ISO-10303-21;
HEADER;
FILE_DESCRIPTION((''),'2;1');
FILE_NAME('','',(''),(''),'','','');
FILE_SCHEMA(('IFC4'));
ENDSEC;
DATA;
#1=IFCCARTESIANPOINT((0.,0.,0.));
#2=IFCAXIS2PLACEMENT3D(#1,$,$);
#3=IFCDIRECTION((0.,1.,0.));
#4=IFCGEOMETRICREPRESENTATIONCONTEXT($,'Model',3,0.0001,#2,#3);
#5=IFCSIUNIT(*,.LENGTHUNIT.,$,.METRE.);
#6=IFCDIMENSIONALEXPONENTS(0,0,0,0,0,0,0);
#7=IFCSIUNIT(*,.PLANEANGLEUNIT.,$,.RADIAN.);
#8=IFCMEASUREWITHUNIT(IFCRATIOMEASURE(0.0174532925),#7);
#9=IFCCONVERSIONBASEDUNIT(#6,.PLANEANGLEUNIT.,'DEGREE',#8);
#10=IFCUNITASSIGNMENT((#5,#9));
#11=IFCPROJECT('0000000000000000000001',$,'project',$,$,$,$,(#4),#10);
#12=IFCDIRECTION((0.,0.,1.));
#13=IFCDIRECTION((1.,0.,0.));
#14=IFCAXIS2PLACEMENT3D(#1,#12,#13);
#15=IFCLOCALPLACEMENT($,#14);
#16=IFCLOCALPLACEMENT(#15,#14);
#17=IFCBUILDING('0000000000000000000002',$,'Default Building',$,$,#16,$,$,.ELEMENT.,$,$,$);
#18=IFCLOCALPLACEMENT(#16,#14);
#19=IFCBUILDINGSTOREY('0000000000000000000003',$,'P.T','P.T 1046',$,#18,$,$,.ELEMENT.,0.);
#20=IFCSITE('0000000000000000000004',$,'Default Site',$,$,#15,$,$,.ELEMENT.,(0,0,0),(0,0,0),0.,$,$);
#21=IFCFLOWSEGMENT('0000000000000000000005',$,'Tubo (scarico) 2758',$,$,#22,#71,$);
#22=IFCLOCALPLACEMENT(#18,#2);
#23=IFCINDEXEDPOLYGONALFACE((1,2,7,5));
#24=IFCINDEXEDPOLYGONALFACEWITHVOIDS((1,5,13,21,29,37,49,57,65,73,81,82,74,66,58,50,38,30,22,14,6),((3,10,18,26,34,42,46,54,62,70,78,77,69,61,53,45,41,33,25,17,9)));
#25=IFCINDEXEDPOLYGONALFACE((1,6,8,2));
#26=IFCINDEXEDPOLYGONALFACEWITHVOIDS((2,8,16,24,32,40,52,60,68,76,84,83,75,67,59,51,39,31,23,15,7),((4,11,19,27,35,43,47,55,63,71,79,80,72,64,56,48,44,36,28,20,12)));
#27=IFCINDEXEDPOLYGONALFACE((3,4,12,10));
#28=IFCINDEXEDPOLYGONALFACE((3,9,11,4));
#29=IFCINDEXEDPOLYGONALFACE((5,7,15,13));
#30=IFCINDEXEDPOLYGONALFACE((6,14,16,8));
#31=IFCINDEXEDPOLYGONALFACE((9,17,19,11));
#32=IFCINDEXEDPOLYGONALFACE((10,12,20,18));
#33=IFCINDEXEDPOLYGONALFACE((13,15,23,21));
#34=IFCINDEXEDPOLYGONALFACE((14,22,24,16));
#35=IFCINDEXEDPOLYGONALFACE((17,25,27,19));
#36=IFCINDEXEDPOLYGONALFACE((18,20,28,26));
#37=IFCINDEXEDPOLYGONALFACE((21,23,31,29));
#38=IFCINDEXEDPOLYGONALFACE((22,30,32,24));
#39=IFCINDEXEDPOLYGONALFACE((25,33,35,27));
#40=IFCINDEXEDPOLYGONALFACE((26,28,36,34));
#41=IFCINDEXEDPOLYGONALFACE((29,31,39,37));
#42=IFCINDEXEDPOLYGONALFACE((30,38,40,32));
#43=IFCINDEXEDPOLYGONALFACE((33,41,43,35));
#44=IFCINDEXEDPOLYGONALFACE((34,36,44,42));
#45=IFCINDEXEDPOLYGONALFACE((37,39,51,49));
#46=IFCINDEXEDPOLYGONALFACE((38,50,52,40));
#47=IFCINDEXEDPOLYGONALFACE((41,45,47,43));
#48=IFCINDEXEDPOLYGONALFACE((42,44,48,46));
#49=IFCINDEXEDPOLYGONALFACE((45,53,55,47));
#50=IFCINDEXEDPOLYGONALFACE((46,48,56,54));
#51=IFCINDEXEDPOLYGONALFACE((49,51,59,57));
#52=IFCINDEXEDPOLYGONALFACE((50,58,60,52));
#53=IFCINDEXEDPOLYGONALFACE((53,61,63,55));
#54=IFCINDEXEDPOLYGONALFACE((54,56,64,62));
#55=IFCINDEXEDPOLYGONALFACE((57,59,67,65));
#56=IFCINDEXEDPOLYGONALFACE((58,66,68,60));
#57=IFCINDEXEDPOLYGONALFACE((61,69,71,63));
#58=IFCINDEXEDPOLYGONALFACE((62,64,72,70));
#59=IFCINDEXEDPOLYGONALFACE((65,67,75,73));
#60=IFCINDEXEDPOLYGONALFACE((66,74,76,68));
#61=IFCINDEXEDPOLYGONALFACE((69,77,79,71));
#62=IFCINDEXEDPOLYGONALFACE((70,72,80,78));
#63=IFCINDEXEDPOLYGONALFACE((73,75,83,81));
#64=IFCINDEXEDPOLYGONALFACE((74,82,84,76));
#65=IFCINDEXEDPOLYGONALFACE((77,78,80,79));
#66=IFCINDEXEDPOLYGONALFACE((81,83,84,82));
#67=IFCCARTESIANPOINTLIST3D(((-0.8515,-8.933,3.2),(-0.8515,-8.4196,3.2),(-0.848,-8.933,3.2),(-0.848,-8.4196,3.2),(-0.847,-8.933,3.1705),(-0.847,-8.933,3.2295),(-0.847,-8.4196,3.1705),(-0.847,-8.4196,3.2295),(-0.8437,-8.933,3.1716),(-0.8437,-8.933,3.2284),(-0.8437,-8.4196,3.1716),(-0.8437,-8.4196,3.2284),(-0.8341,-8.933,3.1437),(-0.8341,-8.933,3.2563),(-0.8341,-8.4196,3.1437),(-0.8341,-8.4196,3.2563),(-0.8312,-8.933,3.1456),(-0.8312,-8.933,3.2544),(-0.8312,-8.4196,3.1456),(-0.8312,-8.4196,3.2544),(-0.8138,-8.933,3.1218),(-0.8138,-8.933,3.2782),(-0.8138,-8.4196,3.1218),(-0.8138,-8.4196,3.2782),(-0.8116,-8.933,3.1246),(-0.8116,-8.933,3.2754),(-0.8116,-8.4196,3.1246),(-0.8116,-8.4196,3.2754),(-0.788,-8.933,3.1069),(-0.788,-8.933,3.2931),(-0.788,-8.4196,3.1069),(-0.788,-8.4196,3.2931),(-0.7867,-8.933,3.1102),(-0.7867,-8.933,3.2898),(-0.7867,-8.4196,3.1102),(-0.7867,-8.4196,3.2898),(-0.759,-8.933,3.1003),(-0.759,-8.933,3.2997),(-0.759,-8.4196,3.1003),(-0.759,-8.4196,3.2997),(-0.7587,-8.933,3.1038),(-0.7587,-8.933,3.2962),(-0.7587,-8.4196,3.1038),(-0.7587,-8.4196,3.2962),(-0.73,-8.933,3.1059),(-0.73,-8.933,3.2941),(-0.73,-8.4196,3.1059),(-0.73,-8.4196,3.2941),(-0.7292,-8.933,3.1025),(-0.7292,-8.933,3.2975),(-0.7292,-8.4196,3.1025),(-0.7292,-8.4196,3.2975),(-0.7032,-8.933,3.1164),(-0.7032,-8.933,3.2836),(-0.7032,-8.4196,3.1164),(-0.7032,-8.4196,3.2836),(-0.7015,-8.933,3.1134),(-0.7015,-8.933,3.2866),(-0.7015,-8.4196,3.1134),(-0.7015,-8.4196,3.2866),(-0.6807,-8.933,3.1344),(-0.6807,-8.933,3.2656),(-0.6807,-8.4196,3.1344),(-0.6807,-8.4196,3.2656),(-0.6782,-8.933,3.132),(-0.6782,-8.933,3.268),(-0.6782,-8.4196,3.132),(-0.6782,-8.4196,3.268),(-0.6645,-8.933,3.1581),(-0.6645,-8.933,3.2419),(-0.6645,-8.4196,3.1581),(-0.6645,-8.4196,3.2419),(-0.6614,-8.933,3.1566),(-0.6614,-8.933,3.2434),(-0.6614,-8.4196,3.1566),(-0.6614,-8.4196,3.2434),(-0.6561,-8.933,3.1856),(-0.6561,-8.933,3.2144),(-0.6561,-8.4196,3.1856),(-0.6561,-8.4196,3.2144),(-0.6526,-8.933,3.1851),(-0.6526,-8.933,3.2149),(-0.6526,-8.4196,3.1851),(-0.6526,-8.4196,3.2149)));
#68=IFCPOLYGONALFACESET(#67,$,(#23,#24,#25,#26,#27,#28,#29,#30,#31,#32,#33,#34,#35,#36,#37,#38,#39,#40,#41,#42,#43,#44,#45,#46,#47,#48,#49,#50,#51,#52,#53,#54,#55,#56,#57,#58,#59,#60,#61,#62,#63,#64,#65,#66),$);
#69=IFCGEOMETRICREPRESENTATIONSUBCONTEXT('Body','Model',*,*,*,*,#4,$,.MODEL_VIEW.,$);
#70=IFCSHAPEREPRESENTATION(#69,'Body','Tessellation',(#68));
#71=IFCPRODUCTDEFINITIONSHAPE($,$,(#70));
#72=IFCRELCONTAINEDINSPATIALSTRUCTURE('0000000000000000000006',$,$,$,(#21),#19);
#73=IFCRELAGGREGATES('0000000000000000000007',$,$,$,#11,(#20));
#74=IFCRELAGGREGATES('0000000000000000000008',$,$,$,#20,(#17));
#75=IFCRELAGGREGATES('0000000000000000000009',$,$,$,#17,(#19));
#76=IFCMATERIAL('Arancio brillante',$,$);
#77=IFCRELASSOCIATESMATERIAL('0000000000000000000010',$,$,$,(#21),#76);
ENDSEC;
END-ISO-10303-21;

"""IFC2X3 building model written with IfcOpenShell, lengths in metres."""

from ifc_helpers import new_model, entity, si_unit, converted_unit, direction, frame, origin, origin_with_axes, origin_2d_with_axis, place, context, subcontext, project, spatial, hollow_circle, extrude, source, transform, mapped, material, element, save


model = new_model("IFC2X3")

# Units and contexts
model_context = context("Model", 3, precision=0.0001, world=origin(), true_north=direction((0.0, 1.0, 0.0)))
body_context = subcontext(model_context, "Body", "Model", "MODEL_VIEW")
ifc_project = project(units=[si_unit("LENGTHUNIT", "METRE"), converted_unit("PLANEANGLEUNIT", "DEGREE", entity("IfcRatioMeasure", 0.0174532925), si_unit("PLANEANGLEUNIT", "RADIAN"), dimensions=[0, 0, 0, 0, 0, 0, 0])], contexts=[model_context])

# Site, building, storey
site_placement = place(None, origin_with_axes())
site = spatial("IfcSite", under=ifc_project, at=site_placement, Name="Default Site", CompositionType="ELEMENT", RefLatitude=(0, 0, 0), RefLongitude=(0, 0, 0), RefElevation=0.0)
building_placement = place(site_placement, origin_with_axes())
building = spatial("IfcBuilding", under=site, at=building_placement, Name="Default Building", CompositionType="ELEMENT")
storey_placement = place(building_placement, frame((0.0, 0.0, 0.0), z_axis=(0.0, 0.0, 1.0), x_axis=(1.0, 0.0, 0.0)))
storey = spatial("IfcBuildingStorey", under=building, at=storey_placement, Name="P.T", Description="P.T 1046", CompositionType="ELEMENT", Elevation=0.0)

# Flow segment
ifc_material_1 = material(Name="Arancio brillante")
shared_shape_1 = source(origin_with_axes(), body_context, "Body", "SweptSolid", [
    extrude(hollow_circle(Radius=0.1, WallThickness=0.0035, at=origin_2d_with_axis()), origin_with_axes(), (0.0, 0.0, 1.0), 1.0),
])
flow_segment_1_placement = place(storey_placement, frame((-0.7515, -8.6763, 3.2), z_axis=(0.0, 1.0, 0.0), x_axis=(-1.0, 0.0, 0.0)))
element("IfcFlowSegment", 1, at=flow_segment_1_placement, inside=storey, material=ifc_material_1, Name="Tubo (scarico) 2758", context=body_context, shape_type="MappedRepresentation", body=[
    mapped(shared_shape_1, transform((0.0, 0.0, -0.2567), x_axis=(1.0, 0.0, 0.0), y_axis=(0.0, 1.0, 0.0), z_axis=(0.0, 0.0, 1.0), scale=1.0, scale2=1.0, scale3=0.513403, uniform=False)),
])

save(model, "model.ifc")
